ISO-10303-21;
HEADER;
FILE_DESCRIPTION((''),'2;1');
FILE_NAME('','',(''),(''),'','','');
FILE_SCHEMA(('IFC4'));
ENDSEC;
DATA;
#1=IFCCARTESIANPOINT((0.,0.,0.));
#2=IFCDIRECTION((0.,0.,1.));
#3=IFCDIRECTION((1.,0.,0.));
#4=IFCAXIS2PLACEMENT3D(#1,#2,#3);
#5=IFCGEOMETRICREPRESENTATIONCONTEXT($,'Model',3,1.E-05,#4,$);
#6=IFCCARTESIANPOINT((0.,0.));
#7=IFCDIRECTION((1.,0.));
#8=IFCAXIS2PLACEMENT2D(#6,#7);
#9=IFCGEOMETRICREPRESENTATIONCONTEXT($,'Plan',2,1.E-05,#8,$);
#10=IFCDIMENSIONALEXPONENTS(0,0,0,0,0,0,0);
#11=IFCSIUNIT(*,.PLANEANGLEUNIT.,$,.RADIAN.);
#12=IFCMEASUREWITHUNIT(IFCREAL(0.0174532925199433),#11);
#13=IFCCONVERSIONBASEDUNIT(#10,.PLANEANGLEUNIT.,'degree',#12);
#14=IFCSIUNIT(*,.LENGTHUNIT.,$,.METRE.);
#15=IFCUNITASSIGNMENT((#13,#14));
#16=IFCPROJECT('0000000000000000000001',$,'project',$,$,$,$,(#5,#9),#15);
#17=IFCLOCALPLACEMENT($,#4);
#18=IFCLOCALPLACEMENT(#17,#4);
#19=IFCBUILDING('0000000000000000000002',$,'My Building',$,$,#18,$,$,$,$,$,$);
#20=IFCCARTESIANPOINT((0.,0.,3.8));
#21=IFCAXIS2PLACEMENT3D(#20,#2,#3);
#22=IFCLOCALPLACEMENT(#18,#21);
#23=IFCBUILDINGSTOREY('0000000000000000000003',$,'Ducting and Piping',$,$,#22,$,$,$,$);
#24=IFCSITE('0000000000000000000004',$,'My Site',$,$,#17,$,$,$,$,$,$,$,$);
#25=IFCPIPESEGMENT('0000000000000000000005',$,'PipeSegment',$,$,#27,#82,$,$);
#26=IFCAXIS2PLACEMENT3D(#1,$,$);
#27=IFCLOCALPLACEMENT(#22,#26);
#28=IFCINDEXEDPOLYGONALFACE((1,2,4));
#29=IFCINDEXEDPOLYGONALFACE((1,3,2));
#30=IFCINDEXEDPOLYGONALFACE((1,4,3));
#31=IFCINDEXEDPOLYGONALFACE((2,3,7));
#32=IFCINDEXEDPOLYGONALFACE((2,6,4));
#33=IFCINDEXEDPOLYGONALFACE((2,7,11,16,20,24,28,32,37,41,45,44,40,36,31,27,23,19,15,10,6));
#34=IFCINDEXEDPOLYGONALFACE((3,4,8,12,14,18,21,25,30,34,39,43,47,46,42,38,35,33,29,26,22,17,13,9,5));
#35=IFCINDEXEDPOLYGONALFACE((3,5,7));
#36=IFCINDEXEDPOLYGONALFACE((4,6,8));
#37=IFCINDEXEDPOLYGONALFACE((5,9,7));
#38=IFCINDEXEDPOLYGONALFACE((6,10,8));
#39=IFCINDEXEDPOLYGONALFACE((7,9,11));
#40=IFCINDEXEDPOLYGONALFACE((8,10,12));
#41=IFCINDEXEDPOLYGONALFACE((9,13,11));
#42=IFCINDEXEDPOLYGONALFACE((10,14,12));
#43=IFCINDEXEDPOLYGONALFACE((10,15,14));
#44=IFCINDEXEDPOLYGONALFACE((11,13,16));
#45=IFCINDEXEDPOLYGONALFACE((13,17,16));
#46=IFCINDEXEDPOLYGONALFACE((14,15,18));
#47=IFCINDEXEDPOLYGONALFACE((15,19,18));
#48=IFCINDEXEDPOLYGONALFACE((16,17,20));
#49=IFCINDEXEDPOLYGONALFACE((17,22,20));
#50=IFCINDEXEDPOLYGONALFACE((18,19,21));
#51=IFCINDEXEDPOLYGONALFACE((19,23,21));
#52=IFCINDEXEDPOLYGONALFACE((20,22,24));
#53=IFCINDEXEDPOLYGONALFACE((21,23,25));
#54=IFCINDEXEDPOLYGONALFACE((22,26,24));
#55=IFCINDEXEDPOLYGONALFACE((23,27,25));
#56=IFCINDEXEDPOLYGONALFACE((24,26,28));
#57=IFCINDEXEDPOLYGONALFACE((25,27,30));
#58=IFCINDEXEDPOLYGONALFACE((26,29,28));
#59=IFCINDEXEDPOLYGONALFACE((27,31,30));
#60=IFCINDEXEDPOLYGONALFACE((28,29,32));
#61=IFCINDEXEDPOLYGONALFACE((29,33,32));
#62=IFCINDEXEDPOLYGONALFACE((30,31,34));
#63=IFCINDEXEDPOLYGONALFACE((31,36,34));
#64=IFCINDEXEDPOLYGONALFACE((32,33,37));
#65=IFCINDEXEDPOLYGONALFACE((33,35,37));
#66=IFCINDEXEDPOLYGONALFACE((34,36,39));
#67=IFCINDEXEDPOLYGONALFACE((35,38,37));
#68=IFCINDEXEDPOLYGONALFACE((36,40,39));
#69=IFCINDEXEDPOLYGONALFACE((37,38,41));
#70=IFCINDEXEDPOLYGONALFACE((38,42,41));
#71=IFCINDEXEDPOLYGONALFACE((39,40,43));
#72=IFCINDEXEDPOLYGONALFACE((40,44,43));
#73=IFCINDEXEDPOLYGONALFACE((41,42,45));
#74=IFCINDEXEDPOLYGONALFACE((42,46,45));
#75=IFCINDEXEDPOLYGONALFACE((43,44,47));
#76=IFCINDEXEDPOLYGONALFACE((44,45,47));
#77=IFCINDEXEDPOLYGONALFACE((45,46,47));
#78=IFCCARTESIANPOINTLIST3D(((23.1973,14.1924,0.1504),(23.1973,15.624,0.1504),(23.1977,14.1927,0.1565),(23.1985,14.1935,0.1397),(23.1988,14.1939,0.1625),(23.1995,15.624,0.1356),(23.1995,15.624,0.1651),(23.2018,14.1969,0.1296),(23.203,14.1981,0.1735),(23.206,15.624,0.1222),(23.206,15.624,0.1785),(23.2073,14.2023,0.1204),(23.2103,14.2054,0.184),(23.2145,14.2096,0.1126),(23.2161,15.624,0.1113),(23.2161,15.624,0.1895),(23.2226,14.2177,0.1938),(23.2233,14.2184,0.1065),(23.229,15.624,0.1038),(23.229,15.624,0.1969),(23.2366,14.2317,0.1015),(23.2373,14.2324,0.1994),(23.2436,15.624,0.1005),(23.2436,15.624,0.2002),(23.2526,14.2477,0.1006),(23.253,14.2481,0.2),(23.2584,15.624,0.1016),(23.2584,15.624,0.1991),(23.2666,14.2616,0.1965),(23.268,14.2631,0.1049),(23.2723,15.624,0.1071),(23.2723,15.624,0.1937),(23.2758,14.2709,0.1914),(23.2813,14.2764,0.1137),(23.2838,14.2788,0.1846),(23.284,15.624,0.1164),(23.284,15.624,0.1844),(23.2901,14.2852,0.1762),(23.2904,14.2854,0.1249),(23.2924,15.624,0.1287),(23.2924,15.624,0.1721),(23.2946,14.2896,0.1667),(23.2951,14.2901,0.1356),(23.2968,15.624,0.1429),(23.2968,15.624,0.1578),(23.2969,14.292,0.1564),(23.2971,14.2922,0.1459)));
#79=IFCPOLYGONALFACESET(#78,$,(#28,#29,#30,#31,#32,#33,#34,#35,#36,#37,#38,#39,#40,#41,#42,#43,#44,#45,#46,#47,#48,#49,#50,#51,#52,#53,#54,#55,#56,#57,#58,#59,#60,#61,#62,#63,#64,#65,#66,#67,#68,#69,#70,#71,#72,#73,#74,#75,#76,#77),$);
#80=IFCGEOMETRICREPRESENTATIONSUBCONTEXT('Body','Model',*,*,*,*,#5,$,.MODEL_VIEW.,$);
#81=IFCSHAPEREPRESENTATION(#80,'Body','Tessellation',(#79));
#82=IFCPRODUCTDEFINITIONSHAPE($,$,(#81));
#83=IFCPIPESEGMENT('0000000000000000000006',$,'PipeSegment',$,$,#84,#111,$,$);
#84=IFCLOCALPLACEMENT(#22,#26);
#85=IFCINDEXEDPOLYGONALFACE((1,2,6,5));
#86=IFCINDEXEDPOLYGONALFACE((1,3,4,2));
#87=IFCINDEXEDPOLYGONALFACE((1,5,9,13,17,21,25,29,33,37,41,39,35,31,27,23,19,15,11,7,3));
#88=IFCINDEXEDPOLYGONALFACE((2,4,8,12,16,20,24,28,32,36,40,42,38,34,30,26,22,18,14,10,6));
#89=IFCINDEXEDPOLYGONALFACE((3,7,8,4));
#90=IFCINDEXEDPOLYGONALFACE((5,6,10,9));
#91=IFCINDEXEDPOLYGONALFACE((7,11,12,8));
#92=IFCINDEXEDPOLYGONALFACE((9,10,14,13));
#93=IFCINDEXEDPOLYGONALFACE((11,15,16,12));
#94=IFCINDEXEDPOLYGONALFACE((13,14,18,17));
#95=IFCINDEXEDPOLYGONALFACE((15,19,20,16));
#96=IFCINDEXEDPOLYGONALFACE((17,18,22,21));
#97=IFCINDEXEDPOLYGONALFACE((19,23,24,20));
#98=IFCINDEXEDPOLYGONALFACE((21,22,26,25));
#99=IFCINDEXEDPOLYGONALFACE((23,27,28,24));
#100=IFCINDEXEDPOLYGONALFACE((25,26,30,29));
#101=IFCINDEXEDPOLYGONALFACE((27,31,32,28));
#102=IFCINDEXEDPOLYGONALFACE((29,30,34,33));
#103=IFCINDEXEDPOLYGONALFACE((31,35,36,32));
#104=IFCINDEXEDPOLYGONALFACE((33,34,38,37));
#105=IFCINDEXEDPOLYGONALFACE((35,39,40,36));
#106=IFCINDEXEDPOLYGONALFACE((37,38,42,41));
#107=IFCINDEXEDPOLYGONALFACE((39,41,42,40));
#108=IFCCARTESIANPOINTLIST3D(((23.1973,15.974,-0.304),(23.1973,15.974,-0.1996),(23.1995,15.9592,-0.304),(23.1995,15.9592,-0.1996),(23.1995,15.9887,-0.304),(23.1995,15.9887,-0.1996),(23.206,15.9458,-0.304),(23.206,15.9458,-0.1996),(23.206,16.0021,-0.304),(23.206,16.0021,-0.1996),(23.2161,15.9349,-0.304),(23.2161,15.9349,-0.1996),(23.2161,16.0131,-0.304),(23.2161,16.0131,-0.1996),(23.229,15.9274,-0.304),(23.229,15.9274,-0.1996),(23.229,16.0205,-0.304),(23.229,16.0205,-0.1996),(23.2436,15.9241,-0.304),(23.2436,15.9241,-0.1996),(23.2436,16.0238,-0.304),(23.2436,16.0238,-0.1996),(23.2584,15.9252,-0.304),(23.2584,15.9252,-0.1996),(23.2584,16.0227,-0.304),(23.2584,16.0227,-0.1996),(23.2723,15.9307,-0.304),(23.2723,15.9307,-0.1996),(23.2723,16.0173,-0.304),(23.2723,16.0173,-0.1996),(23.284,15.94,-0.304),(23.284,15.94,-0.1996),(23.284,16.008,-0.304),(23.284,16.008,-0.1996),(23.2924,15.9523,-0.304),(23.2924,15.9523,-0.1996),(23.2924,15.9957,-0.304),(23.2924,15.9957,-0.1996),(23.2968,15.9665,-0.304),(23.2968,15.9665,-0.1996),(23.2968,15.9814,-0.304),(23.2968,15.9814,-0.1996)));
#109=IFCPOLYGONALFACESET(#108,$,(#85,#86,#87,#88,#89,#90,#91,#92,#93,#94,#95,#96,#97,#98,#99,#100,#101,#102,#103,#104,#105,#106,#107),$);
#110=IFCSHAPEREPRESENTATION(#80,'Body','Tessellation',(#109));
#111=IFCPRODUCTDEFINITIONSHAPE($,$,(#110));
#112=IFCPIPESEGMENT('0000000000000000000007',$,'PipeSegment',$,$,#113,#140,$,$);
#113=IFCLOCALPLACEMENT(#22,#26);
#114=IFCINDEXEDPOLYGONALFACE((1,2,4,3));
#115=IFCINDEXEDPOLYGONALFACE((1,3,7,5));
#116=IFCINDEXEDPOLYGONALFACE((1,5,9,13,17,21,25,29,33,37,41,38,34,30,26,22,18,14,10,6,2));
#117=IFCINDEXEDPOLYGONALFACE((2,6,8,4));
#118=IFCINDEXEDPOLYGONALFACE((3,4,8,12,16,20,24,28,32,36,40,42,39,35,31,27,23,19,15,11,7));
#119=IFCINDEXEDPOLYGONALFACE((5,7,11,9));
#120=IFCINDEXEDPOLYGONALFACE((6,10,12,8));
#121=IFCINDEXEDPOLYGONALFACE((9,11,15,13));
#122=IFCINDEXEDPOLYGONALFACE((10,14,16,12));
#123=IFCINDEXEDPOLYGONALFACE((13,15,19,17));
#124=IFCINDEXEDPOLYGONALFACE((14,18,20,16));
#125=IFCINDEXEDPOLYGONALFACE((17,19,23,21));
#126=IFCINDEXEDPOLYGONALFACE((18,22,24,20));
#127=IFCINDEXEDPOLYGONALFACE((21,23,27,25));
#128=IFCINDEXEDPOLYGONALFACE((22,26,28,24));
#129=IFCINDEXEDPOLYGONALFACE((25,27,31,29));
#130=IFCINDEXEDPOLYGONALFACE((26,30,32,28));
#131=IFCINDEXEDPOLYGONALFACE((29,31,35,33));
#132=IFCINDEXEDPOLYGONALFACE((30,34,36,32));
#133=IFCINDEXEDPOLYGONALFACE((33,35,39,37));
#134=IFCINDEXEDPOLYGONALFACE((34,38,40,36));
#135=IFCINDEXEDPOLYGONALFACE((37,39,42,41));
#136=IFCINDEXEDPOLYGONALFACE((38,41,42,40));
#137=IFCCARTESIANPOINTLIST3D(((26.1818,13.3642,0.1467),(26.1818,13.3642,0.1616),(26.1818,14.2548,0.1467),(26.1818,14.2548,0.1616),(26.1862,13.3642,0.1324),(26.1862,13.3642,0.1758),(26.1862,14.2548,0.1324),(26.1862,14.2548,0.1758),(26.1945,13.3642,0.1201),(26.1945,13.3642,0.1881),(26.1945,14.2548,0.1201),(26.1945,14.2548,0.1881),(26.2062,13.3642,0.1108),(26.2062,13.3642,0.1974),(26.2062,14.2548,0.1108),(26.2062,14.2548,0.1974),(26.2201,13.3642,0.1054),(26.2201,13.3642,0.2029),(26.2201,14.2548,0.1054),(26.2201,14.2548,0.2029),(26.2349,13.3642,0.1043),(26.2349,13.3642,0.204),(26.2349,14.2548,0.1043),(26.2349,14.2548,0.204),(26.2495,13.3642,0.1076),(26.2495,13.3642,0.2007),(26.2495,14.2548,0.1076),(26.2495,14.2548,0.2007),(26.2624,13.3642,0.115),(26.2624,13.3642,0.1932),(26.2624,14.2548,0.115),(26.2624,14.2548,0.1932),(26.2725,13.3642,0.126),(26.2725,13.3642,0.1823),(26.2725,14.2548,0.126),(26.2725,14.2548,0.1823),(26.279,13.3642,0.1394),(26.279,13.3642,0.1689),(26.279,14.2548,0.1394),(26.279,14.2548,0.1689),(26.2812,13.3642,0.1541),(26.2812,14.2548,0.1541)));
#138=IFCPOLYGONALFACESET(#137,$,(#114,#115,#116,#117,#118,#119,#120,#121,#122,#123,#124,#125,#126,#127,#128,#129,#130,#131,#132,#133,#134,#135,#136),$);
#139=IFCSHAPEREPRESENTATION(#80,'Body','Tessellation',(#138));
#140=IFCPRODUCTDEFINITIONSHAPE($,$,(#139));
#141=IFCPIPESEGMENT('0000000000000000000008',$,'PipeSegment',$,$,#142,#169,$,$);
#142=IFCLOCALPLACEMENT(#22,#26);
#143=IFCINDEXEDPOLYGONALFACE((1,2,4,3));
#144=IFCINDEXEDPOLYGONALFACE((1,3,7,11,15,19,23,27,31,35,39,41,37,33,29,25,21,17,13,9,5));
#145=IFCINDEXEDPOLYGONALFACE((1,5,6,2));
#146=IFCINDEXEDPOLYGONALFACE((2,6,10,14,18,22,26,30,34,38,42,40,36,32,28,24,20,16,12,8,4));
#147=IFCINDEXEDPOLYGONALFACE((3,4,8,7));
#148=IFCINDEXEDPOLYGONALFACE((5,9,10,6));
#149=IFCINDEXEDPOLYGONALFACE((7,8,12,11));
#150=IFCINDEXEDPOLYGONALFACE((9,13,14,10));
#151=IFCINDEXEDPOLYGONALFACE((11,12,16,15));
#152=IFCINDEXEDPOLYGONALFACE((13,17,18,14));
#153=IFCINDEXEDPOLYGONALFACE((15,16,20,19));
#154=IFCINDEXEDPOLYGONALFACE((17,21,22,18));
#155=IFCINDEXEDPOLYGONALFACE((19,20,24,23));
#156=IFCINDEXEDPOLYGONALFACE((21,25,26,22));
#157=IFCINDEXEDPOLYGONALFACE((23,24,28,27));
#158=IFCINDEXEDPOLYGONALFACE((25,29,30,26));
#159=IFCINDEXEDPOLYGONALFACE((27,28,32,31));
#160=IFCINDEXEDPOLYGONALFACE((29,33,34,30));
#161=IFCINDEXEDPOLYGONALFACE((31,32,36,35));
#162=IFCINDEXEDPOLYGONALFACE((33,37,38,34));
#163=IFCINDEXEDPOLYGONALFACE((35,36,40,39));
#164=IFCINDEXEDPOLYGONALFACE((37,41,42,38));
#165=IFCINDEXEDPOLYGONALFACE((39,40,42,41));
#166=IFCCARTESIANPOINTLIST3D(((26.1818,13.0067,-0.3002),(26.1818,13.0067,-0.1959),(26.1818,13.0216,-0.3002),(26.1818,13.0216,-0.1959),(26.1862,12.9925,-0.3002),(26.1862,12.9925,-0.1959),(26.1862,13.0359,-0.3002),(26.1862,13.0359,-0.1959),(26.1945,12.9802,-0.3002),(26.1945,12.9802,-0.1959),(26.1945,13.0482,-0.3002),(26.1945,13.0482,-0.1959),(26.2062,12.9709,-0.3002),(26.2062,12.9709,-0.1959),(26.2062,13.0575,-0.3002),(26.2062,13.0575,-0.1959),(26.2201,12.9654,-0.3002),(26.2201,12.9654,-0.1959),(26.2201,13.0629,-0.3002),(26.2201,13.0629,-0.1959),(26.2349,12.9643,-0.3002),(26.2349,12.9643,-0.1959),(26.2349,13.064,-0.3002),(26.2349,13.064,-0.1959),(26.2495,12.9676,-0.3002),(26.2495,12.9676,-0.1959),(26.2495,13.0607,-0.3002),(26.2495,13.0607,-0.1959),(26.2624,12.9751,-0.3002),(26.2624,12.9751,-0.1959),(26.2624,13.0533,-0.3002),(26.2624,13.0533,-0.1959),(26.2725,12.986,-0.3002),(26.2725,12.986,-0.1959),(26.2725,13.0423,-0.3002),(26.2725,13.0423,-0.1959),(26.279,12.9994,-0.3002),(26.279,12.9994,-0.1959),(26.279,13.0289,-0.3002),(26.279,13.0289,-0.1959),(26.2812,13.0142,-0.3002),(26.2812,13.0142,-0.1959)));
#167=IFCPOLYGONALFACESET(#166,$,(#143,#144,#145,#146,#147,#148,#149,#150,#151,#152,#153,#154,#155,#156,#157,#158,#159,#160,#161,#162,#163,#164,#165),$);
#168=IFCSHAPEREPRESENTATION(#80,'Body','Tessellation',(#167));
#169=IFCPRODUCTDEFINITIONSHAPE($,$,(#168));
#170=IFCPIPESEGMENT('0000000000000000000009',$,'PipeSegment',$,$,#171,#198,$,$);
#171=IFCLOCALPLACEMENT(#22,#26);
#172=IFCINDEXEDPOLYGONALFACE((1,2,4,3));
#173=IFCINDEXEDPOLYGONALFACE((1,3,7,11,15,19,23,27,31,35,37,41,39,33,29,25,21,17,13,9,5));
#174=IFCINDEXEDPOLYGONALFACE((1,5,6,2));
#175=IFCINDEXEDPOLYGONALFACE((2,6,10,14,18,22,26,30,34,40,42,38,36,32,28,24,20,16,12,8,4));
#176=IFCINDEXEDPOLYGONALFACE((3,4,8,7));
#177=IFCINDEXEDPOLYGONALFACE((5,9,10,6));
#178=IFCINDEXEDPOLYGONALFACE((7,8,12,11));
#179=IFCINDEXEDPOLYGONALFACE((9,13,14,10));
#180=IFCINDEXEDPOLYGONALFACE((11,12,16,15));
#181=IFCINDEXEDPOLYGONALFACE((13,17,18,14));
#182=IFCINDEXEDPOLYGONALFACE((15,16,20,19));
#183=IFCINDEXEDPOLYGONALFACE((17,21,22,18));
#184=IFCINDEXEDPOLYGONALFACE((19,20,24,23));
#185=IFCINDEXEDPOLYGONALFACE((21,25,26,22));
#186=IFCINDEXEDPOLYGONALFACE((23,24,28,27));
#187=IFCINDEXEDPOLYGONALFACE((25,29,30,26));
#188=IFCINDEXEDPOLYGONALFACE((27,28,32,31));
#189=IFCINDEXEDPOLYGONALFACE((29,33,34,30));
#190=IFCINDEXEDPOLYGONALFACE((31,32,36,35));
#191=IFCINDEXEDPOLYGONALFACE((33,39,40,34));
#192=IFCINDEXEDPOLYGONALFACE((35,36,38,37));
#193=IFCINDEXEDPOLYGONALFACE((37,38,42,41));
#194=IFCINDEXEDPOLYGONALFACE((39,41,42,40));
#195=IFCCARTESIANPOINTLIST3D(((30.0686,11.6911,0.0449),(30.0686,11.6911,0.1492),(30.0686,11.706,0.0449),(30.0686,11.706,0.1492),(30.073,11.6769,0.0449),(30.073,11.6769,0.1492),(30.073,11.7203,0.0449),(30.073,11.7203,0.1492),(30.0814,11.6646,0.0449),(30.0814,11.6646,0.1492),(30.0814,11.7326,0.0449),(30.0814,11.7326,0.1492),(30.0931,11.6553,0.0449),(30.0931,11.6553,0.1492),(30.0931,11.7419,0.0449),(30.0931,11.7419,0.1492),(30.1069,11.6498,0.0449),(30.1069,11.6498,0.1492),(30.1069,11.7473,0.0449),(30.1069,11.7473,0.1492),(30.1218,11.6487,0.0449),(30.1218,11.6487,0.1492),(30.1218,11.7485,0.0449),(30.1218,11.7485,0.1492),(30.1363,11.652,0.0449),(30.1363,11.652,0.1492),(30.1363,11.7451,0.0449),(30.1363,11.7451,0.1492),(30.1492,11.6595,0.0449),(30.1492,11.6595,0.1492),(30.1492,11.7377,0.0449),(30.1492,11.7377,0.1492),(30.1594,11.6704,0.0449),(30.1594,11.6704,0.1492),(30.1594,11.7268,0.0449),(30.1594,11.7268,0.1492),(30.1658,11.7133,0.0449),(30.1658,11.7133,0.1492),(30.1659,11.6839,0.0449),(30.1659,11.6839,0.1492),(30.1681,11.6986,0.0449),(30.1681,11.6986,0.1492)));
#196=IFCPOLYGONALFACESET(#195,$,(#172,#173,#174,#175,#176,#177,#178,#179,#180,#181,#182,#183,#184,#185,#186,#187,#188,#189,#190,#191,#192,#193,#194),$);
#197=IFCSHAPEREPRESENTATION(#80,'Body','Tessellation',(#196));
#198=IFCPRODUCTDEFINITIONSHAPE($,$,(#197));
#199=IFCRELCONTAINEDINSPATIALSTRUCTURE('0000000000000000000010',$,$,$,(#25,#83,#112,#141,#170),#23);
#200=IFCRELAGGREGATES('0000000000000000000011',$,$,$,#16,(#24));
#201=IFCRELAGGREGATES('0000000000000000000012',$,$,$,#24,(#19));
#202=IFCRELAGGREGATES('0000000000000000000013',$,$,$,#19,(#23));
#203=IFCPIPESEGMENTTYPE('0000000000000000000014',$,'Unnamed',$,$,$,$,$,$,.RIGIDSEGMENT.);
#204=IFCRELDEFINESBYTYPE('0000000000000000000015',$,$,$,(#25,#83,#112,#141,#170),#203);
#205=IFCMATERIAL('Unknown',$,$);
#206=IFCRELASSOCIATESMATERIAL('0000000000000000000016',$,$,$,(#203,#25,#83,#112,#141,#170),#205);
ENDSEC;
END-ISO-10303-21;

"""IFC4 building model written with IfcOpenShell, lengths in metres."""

from ifc_helpers import new_model, entity, si_unit, converted_unit, frame, origin_with_axes, origin_2d_with_axis, place, context, subcontext, project, spatial, circle, extrude, clip, halfspace, material, material_profile, profile_set, profile_usage, type_object, element, save


model = new_model("IFC4")

# Units and contexts
model_context = context("Model", 3, precision=1e-05, world=origin_with_axes())
plan_context = context("Plan", 2, precision=1e-05, world=origin_2d_with_axis())
body_context = subcontext(model_context, "Body", "Model", "MODEL_VIEW")
ifc_project = project(units=[converted_unit("PLANEANGLEUNIT", "degree", entity("IfcReal", 0.0174532925199433), si_unit("PLANEANGLEUNIT", "RADIAN"), dimensions=[0, 0, 0, 0, 0, 0, 0]), si_unit("LENGTHUNIT", "METRE")], contexts=[model_context, plan_context])

# Site, building, storey
site_placement = place(None, origin_with_axes())
site = spatial("IfcSite", under=ifc_project, at=site_placement, Name="My Site")
building_placement = place(site_placement, origin_with_axes())
building = spatial("IfcBuilding", under=site, at=building_placement, Name="My Building")
storey_placement = place(building_placement, frame((0.0, 0.0, 3.8), z_axis=(0.0, 0.0, 1.0), x_axis=(1.0, 0.0, 0.0)))
storey = spatial("IfcBuildingStorey", under=building, at=storey_placement, Name="Ducting and Piping")

# Pipe segments
ifc_material = material(Name="Unknown")
ifc_material_profile_1 = material_profile(ifc_material, circle(Radius=0.05))
ifc_profile_set_1 = profile_set([ifc_material_profile_1])
pipe_segment_type = type_object("IfcPipeSegmentType", Name="Unnamed", PredefinedType="RIGIDSEGMENT", material=ifc_profile_set_1)
ifc_profile_usage_1 = profile_usage(ifc_profile_set_1, cardinal=5)
pipe_segment_1_placement = place(storey_placement, frame((23.2473, 14.1924, 0.1504), z_axis=(0.0, 1.0, 0.0), x_axis=(-1.0, 0.0, 0.0)))
element("IfcPipeSegment", 1, at=pipe_segment_1_placement, inside=storey, type_object=pipe_segment_type, material=ifc_profile_usage_1, Name="PipeSegment", context=body_context, shape_type="Clipping", body=[
    clip(extrude(circle(Radius=0.05), origin_with_axes(), (0.0, 0.0, 1.0), 1.4316), halfspace(frame((0.05, -3.9831, 0.0), z_axis=(-0.707114, 0.0, -0.7071), x_axis=(0.0, 1.0, 0.0)), False)),
])
ifc_profile_usage_2 = profile_usage(ifc_profile_set_1, cardinal=5)
pipe_segment_2_placement = place(storey_placement, frame((23.2473, 15.974, -0.304), z_axis=(0.0, 0.0, 1.0), x_axis=(-1.0, 0.0, 0.0)))
element("IfcPipeSegment", 2, at=pipe_segment_2_placement, inside=storey, type_object=pipe_segment_type, material=ifc_profile_usage_2, Name="PipeSegment", context=body_context, shape_type="SweptSolid", body=[
    extrude(circle(Radius=0.05), origin_with_axes(), (0.0, 0.0, 1.0), 0.1043),
])
ifc_profile_usage_3 = profile_usage(ifc_profile_set_1, cardinal=5)
pipe_segment_3_placement = place(storey_placement, frame((26.2312, 14.2548, 0.1541), z_axis=(0.0, -1.0, 0.0), x_axis=(1.0, 0.0, 0.0)))
element("IfcPipeSegment", 3, at=pipe_segment_3_placement, inside=storey, type_object=pipe_segment_type, material=ifc_profile_usage_3, Name="PipeSegment", context=body_context, shape_type="SweptSolid", body=[
    extrude(circle(Radius=0.05), origin_with_axes(), (0.0, 0.0, 1.0), 0.8907),
])
ifc_profile_usage_4 = profile_usage(ifc_profile_set_1, cardinal=5)
pipe_segment_4_placement = place(storey_placement, frame((26.2312, 13.0142, -0.3002), z_axis=(0.0, 0.0, 1.0), x_axis=(1.0, 0.0, 0.0)))
element("IfcPipeSegment", 4, at=pipe_segment_4_placement, inside=storey, type_object=pipe_segment_type, material=ifc_profile_usage_4, Name="PipeSegment", context=body_context, shape_type="SweptSolid", body=[
    extrude(circle(Radius=0.05), origin_with_axes(), (0.0, 0.0, 1.0), 0.1043),
])
ifc_profile_usage_5 = profile_usage(ifc_profile_set_1, cardinal=5)
pipe_segment_5_placement = place(storey_placement, frame((30.1181, 11.6986, 0.0449), z_axis=(0.0, 0.0, 1.0), x_axis=(1.0, 0.00006, 0.0)))
element("IfcPipeSegment", 5, at=pipe_segment_5_placement, inside=storey, type_object=pipe_segment_type, material=ifc_profile_usage_5, Name="PipeSegment", context=body_context, shape_type="SweptSolid", body=[
    extrude(circle(Radius=0.05), origin_with_axes(), (0.0, 0.0, 1.0), 0.1043),
])

save(model, "model.ifc")
